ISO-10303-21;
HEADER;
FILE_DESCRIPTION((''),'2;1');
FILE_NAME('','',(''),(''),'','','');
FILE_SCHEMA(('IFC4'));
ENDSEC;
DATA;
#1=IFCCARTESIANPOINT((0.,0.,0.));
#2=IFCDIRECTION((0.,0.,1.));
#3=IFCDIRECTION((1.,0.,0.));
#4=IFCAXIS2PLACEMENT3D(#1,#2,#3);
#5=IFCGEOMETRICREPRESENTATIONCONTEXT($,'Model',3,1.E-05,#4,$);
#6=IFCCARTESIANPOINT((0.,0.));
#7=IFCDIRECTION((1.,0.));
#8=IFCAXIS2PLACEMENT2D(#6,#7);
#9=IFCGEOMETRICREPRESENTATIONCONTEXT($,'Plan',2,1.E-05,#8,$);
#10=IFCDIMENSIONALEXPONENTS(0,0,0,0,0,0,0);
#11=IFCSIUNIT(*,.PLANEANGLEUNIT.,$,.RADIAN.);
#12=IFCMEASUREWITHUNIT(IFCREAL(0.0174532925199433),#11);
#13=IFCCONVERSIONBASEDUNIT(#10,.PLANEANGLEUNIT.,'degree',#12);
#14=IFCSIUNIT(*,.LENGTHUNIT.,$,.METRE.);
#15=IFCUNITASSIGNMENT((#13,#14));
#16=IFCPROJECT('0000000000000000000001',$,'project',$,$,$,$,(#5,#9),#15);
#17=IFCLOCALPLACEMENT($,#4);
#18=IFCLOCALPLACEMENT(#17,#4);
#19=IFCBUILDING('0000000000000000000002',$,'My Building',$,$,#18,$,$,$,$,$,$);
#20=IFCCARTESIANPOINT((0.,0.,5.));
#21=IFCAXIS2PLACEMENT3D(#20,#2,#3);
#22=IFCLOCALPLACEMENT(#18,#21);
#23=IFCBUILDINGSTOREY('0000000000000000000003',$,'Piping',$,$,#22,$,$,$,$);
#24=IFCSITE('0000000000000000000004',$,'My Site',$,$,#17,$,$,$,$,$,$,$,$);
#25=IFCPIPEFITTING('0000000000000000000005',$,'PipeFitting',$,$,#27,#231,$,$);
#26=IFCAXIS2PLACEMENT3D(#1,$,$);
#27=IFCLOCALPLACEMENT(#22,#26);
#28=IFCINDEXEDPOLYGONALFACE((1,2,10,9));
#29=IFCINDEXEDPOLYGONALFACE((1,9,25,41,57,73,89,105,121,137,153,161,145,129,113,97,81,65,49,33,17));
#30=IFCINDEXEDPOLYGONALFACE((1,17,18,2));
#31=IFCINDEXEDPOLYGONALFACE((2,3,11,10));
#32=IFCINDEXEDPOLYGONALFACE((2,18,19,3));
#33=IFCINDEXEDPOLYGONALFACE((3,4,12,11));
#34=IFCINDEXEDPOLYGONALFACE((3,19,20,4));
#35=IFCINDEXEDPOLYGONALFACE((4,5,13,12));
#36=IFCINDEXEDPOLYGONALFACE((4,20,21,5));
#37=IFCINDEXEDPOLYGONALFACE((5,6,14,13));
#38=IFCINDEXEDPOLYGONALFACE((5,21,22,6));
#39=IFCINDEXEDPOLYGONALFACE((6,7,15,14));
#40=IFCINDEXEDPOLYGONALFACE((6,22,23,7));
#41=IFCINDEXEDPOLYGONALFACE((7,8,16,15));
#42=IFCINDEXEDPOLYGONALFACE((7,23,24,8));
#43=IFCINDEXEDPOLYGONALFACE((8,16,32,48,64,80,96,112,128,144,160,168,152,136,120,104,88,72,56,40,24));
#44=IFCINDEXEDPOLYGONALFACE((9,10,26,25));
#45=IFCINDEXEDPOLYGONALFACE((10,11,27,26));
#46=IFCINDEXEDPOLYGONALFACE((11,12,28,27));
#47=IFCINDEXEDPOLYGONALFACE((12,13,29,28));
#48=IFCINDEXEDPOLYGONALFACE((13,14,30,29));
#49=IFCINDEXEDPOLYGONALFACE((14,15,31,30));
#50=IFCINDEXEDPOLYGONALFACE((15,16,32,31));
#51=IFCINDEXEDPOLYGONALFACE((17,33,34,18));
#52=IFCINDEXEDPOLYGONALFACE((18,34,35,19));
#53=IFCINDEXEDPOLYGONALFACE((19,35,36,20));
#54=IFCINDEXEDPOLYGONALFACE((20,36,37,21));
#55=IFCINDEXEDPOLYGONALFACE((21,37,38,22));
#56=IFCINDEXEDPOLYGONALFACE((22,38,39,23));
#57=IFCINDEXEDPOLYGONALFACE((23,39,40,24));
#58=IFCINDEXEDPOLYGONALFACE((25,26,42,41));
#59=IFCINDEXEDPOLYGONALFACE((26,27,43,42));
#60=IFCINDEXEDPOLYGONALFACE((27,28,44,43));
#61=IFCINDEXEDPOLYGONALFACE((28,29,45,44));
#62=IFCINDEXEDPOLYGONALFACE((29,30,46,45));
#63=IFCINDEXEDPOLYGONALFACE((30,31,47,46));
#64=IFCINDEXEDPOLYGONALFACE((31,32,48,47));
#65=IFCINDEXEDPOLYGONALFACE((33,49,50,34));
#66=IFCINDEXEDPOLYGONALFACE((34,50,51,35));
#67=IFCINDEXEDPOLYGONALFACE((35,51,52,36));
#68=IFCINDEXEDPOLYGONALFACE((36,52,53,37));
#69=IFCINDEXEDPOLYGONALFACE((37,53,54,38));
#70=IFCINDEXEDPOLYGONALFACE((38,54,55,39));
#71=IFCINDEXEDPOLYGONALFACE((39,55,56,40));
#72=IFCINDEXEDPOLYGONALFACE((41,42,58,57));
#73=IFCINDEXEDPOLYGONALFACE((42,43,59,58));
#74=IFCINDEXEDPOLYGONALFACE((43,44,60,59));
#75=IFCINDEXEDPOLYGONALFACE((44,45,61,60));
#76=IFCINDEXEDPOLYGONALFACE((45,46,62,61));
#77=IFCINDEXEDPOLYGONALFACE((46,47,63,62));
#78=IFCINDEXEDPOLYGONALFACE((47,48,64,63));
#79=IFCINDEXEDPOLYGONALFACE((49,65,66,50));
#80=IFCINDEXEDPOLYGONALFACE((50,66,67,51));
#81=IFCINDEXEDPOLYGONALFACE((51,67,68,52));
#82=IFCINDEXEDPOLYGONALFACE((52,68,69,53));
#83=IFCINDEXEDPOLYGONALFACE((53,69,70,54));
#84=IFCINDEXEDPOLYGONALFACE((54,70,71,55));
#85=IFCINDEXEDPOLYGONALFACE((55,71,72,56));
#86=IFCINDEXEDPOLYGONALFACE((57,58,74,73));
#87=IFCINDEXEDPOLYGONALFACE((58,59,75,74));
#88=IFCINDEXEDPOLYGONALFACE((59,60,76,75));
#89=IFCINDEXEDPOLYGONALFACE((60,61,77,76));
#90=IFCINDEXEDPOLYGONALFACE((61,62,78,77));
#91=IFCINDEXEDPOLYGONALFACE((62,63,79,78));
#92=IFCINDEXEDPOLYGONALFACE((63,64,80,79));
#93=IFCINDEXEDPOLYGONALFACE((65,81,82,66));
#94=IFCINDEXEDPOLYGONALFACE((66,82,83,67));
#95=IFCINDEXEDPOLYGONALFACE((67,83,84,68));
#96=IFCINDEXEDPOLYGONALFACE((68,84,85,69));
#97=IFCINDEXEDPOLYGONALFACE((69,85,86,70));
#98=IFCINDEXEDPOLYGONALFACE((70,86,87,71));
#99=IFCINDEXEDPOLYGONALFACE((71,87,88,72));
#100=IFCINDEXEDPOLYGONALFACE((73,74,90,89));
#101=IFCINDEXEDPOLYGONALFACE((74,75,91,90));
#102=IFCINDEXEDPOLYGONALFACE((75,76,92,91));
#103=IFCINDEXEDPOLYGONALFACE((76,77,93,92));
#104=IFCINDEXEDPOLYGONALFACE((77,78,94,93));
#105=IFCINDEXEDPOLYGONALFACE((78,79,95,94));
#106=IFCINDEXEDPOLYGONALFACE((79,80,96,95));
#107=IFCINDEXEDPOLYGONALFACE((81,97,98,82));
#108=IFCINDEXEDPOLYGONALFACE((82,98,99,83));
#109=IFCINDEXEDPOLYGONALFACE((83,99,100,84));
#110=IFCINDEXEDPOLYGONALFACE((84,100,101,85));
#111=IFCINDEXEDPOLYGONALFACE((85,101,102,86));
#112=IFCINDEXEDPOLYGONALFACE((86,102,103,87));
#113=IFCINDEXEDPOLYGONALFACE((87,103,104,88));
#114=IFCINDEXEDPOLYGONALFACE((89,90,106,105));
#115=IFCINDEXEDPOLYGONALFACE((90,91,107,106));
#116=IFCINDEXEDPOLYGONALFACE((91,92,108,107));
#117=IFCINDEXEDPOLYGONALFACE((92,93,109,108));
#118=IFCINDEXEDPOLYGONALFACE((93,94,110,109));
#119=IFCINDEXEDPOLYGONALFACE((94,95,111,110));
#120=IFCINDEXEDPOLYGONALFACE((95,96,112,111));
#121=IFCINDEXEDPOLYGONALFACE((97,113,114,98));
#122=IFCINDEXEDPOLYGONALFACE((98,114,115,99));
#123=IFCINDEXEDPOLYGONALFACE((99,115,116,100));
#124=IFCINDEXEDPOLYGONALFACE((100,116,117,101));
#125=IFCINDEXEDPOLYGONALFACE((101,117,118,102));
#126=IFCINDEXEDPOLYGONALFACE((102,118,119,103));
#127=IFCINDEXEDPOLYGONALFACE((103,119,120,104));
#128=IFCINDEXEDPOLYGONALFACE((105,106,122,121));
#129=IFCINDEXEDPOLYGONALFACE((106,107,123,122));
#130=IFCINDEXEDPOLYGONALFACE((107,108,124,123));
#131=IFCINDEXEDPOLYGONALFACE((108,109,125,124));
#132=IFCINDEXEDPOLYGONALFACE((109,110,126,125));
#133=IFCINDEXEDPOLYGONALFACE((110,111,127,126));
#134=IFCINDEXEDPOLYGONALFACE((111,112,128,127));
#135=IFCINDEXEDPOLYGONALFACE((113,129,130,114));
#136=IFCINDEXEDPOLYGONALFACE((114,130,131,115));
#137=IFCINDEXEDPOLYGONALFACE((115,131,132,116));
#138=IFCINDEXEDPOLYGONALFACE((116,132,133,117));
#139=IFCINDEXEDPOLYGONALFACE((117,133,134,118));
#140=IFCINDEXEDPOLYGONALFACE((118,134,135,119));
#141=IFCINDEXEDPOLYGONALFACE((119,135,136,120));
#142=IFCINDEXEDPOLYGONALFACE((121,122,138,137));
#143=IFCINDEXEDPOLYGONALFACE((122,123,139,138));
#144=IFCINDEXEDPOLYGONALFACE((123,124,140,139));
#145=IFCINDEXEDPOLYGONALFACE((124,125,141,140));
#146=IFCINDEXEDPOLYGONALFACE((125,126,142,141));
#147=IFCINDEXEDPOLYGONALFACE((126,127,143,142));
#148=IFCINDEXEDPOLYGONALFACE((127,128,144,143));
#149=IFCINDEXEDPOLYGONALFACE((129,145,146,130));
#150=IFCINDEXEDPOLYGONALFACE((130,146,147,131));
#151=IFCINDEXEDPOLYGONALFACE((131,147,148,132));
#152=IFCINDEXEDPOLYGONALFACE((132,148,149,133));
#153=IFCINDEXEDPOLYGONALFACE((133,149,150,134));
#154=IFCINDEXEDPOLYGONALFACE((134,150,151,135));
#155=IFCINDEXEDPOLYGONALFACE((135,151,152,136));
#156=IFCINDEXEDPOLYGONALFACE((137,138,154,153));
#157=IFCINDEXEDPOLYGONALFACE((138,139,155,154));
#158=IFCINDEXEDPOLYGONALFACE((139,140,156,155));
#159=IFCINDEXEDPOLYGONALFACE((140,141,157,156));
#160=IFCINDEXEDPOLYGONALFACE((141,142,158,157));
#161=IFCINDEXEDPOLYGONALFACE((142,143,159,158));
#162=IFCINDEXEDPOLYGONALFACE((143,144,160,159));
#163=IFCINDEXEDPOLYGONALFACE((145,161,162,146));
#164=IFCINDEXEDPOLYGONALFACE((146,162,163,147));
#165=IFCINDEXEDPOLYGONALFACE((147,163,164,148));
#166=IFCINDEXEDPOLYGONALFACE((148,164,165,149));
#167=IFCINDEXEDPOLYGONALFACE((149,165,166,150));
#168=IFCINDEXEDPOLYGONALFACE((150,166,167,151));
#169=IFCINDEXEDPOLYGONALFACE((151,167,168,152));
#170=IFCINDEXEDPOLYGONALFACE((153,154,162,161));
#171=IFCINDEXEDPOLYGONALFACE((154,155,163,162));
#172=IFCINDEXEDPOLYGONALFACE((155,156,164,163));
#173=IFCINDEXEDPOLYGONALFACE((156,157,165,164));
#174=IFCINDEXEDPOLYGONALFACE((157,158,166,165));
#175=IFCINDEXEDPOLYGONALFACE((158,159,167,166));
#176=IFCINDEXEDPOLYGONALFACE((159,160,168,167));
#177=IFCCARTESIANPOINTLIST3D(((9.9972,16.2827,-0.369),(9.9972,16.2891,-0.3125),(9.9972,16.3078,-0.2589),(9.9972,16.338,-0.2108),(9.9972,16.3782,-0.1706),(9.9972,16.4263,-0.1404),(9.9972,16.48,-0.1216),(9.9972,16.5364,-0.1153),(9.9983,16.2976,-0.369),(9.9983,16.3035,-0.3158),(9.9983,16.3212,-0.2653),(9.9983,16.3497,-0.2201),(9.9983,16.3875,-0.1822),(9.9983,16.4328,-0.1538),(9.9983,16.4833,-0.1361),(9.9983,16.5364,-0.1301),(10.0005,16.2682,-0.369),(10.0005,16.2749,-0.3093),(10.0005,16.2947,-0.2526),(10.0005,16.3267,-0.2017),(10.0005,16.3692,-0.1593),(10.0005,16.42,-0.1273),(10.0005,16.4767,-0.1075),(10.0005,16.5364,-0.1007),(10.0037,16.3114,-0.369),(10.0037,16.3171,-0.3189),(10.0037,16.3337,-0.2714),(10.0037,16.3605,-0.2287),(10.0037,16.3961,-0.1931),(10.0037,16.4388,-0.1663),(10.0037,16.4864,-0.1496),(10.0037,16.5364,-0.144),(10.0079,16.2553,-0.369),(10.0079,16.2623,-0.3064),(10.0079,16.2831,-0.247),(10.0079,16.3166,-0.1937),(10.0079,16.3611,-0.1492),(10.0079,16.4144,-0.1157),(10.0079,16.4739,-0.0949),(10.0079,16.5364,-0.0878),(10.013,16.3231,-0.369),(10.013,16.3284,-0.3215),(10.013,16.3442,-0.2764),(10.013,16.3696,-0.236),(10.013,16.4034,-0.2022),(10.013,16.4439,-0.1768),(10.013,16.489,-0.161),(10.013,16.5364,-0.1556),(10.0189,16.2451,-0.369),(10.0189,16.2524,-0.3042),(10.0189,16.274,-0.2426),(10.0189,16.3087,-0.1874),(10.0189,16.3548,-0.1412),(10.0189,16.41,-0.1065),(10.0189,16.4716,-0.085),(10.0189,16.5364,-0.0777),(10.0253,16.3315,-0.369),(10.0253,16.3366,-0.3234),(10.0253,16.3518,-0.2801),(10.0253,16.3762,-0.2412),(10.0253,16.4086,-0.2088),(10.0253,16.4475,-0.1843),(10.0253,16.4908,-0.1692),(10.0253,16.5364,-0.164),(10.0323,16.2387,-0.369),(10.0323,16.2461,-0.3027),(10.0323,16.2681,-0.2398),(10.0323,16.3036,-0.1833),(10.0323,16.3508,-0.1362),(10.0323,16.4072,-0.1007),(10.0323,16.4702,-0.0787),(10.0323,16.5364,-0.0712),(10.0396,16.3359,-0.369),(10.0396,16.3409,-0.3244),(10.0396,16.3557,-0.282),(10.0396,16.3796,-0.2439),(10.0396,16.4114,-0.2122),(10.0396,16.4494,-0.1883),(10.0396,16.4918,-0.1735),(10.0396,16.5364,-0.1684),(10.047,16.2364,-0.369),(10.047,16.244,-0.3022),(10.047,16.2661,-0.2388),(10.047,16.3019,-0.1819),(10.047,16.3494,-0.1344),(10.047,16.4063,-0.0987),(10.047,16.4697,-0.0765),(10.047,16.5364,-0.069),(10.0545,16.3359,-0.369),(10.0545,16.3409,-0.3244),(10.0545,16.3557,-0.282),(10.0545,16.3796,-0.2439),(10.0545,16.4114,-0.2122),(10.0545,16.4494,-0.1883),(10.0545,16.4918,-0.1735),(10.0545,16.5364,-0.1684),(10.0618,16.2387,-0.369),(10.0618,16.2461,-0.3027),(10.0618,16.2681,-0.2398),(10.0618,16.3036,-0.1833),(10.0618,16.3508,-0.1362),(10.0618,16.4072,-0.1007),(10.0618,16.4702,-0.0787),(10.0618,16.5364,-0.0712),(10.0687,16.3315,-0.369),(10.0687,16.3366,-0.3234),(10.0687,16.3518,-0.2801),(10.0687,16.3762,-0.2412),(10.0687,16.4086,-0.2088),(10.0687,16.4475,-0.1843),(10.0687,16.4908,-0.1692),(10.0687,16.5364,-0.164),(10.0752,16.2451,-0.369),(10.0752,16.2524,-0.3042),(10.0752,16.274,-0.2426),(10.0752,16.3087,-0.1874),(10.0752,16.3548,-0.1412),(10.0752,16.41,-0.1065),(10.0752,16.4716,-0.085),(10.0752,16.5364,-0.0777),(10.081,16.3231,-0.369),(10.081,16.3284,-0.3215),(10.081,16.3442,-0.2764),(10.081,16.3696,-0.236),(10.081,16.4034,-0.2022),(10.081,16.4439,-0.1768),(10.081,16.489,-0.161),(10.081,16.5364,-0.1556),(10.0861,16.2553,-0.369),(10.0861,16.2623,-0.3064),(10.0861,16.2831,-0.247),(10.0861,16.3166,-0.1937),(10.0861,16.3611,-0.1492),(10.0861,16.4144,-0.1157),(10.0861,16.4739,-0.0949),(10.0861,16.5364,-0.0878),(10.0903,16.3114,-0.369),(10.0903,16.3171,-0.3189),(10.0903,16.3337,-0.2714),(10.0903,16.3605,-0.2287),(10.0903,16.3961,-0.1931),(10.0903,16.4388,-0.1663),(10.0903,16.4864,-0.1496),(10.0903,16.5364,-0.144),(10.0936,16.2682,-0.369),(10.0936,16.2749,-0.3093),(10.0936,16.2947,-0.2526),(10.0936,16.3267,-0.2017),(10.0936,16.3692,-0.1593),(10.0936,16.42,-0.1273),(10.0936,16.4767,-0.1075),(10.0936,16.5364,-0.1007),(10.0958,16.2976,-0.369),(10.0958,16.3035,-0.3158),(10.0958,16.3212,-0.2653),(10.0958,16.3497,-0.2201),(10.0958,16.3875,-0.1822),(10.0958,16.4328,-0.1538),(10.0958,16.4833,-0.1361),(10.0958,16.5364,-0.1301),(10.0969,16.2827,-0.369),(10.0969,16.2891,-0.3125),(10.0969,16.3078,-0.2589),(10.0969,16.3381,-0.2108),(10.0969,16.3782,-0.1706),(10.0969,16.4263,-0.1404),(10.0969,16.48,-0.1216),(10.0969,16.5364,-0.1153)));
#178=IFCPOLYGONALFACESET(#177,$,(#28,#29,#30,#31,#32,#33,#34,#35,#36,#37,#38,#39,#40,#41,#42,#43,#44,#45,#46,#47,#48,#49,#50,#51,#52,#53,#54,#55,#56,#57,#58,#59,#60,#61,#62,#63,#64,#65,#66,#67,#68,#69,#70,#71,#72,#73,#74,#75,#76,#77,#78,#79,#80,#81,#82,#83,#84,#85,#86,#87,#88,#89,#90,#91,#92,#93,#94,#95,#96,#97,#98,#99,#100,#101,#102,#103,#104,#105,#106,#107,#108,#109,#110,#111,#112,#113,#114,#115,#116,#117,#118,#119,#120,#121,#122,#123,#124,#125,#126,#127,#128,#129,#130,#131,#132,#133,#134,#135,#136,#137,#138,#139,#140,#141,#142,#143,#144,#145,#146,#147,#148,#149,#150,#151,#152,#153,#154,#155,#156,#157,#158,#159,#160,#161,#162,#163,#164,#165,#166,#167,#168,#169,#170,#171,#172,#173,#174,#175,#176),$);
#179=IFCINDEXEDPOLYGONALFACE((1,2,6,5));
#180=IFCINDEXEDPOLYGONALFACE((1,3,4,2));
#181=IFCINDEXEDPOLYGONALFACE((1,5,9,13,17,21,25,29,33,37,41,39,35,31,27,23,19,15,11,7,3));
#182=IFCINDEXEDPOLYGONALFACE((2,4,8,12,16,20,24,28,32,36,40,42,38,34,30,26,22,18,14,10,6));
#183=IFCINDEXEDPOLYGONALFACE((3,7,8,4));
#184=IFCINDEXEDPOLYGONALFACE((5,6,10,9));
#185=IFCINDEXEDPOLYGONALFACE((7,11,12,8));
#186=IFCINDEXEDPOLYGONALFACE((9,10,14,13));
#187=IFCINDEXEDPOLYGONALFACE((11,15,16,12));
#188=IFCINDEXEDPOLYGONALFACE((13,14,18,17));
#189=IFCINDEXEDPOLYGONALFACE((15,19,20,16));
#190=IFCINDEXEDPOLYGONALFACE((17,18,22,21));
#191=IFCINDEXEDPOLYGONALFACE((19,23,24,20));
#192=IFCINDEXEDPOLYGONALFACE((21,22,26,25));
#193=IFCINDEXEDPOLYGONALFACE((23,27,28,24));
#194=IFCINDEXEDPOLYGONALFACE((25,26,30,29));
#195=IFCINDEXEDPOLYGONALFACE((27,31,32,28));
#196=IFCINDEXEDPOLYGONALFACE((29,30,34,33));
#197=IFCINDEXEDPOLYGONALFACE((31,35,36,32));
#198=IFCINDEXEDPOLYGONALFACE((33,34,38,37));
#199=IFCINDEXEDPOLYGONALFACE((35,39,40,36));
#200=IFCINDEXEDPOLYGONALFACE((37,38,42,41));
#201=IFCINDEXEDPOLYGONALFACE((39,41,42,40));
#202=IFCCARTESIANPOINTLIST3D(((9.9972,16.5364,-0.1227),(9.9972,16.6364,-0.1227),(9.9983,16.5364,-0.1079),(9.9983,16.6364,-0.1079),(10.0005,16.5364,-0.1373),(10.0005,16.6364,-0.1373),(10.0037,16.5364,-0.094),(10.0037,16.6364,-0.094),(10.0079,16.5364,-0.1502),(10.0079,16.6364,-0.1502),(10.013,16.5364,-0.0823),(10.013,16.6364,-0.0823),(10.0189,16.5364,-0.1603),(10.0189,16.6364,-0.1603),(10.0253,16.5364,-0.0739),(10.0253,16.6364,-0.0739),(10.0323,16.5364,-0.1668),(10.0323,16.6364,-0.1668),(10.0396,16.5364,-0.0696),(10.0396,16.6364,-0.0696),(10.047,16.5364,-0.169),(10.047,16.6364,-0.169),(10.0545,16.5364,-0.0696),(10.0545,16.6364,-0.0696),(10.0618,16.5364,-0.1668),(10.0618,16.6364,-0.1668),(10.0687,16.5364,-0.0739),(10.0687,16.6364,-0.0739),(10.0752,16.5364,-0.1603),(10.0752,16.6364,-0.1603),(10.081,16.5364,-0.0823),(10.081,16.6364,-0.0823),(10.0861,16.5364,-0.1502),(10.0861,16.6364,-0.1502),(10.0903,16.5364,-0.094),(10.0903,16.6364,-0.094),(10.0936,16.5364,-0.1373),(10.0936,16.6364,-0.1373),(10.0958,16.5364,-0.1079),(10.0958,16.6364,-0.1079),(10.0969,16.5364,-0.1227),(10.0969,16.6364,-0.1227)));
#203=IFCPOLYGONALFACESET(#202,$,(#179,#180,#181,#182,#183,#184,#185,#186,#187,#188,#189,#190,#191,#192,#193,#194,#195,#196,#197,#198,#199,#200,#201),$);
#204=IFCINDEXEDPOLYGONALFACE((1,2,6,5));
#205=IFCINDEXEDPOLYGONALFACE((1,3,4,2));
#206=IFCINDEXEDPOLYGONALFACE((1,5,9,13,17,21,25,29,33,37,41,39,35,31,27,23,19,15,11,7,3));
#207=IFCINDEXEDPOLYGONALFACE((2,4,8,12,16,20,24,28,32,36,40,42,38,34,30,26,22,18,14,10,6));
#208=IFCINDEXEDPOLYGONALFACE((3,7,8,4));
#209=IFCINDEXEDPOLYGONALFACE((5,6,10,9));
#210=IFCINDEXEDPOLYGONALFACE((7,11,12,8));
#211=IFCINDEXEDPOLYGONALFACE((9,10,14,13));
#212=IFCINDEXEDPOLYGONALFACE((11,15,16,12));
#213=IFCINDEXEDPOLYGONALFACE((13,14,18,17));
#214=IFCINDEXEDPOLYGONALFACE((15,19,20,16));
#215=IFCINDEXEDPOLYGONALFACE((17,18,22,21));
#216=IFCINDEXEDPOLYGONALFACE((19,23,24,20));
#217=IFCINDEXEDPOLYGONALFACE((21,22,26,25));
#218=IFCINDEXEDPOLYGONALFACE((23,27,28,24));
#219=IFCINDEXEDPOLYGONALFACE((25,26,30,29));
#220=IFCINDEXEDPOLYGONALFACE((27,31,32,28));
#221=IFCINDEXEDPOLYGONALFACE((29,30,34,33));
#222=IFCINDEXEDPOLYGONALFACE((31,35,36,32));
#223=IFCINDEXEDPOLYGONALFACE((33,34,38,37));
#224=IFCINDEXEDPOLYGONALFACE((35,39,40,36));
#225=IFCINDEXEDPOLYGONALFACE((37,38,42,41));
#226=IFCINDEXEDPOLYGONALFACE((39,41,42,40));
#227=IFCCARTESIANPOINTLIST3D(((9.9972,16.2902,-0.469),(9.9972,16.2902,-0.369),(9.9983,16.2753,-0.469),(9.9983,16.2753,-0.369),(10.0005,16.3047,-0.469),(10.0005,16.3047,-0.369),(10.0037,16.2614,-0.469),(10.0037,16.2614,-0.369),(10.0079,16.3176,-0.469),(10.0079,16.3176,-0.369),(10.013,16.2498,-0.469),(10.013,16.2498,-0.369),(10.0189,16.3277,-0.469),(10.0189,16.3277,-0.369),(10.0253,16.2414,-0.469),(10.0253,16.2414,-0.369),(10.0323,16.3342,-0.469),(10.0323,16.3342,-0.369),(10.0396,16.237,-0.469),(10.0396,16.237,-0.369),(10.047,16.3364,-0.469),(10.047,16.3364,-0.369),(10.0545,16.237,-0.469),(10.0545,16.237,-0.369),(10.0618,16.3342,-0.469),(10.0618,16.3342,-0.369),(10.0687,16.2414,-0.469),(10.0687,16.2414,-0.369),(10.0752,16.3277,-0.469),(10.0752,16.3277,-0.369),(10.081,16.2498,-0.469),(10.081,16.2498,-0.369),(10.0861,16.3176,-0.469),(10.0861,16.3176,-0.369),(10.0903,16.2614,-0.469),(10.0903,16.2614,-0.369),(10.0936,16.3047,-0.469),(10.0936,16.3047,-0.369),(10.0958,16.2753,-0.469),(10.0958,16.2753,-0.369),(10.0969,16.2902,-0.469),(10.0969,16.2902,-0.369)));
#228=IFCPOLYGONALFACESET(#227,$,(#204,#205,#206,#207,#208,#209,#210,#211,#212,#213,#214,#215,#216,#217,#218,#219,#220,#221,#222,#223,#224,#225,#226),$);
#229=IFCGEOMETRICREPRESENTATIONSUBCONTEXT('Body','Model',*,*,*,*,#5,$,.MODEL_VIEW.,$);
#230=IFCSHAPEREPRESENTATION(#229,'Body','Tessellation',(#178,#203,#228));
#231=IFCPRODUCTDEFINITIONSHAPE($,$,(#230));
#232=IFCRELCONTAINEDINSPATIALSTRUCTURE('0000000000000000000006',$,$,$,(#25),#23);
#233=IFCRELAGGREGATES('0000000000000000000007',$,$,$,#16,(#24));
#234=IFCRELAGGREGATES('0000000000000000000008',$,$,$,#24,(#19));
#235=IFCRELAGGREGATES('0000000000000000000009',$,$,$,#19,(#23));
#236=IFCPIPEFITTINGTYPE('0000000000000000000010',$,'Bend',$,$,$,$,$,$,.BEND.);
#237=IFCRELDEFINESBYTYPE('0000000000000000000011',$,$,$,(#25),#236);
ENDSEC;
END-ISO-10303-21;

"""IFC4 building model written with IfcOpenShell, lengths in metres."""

from ifc_helpers import new_model, entity, si_unit, converted_unit, frame, origin_with_axes, origin_2d_with_axis, place, context, subcontext, project, spatial, circle, extrude, source, transform, mapped, type_object, type_shapes, element, save


model = new_model("IFC4")

# Units and contexts
model_context = context("Model", 3, precision=1e-05, world=origin_with_axes())
plan_context = context("Plan", 2, precision=1e-05, world=origin_2d_with_axis())
body_context = subcontext(model_context, "Body", "Model", "MODEL_VIEW")
ifc_project = project(units=[converted_unit("PLANEANGLEUNIT", "degree", entity("IfcReal", 0.0174532925199433), si_unit("PLANEANGLEUNIT", "RADIAN"), dimensions=[0, 0, 0, 0, 0, 0, 0]), si_unit("LENGTHUNIT", "METRE")], contexts=[model_context, plan_context])

# Site, building, storey
site_placement = place(None, origin_with_axes())
site = spatial("IfcSite", under=ifc_project, at=site_placement, Name="My Site")
building_placement = place(site_placement, origin_with_axes())
building = spatial("IfcBuilding", under=site, at=building_placement, Name="My Building")
storey_placement = place(building_placement, frame((0.0, 0.0, 5.0), z_axis=(0.0, 0.0, 1.0), x_axis=(1.0, 0.0, 0.0)))
storey = spatial("IfcBuildingStorey", under=building, at=storey_placement, Name="Piping")

# Pipe fitting
pipe_fitting_type_1 = type_object("IfcPipeFittingType", Name="Bend", PredefinedType="BEND")
shared_shape = source(origin_with_axes(), body_context, "Body", "SolidModel", [
    entity("IfcSweptDiskSolid", entity("IfcIndexedPolyCurve", entity("IfcCartesianPointList3D", [[0.0, 0.0, -0.1], [0.0732, 0.0, -0.2768], [0.25, 0.0, -0.35]]), [entity("IfcArcIndex", [1, 2, 3])]), 0.05),
    extrude(circle(Radius=0.05), origin_with_axes(), (0.0, 0.0, -1.0), 0.1),
    extrude(circle(Radius=0.05), frame((0.25, 0.0, -0.35), z_axis=(1.0, 0.0, 0.0), x_axis=(0.0, 0.0, 1.0)), (0.0, 0.0, 1.0), 0.1),
])
type_shapes(pipe_fitting_type_1, [shared_shape])
for number, where, z_axis, x_axis, name in (
    (1, (10.047, 16.6364, -0.119), (-0.00006, 1.0, 0.0), (0.0, 0.0, -1.0), "PipeFitting"),
):
    element("IfcPipeFitting", number, at=place(storey_placement, frame(where, z_axis=z_axis, x_axis=x_axis)), inside=storey, type_object=pipe_fitting_type_1, Name=name, context=body_context, shape_type="MappedRepresentation", body=[
        mapped(shared_shape, transform((0.0, 0.0, 0.0), x_axis=(1.0, 0.0, 0.0), y_axis=(0.0, 1.0, 0.0), z_axis=(0.0, 0.0, 1.0), scale=1.0)),
    ])

save(model, "model.ifc")
